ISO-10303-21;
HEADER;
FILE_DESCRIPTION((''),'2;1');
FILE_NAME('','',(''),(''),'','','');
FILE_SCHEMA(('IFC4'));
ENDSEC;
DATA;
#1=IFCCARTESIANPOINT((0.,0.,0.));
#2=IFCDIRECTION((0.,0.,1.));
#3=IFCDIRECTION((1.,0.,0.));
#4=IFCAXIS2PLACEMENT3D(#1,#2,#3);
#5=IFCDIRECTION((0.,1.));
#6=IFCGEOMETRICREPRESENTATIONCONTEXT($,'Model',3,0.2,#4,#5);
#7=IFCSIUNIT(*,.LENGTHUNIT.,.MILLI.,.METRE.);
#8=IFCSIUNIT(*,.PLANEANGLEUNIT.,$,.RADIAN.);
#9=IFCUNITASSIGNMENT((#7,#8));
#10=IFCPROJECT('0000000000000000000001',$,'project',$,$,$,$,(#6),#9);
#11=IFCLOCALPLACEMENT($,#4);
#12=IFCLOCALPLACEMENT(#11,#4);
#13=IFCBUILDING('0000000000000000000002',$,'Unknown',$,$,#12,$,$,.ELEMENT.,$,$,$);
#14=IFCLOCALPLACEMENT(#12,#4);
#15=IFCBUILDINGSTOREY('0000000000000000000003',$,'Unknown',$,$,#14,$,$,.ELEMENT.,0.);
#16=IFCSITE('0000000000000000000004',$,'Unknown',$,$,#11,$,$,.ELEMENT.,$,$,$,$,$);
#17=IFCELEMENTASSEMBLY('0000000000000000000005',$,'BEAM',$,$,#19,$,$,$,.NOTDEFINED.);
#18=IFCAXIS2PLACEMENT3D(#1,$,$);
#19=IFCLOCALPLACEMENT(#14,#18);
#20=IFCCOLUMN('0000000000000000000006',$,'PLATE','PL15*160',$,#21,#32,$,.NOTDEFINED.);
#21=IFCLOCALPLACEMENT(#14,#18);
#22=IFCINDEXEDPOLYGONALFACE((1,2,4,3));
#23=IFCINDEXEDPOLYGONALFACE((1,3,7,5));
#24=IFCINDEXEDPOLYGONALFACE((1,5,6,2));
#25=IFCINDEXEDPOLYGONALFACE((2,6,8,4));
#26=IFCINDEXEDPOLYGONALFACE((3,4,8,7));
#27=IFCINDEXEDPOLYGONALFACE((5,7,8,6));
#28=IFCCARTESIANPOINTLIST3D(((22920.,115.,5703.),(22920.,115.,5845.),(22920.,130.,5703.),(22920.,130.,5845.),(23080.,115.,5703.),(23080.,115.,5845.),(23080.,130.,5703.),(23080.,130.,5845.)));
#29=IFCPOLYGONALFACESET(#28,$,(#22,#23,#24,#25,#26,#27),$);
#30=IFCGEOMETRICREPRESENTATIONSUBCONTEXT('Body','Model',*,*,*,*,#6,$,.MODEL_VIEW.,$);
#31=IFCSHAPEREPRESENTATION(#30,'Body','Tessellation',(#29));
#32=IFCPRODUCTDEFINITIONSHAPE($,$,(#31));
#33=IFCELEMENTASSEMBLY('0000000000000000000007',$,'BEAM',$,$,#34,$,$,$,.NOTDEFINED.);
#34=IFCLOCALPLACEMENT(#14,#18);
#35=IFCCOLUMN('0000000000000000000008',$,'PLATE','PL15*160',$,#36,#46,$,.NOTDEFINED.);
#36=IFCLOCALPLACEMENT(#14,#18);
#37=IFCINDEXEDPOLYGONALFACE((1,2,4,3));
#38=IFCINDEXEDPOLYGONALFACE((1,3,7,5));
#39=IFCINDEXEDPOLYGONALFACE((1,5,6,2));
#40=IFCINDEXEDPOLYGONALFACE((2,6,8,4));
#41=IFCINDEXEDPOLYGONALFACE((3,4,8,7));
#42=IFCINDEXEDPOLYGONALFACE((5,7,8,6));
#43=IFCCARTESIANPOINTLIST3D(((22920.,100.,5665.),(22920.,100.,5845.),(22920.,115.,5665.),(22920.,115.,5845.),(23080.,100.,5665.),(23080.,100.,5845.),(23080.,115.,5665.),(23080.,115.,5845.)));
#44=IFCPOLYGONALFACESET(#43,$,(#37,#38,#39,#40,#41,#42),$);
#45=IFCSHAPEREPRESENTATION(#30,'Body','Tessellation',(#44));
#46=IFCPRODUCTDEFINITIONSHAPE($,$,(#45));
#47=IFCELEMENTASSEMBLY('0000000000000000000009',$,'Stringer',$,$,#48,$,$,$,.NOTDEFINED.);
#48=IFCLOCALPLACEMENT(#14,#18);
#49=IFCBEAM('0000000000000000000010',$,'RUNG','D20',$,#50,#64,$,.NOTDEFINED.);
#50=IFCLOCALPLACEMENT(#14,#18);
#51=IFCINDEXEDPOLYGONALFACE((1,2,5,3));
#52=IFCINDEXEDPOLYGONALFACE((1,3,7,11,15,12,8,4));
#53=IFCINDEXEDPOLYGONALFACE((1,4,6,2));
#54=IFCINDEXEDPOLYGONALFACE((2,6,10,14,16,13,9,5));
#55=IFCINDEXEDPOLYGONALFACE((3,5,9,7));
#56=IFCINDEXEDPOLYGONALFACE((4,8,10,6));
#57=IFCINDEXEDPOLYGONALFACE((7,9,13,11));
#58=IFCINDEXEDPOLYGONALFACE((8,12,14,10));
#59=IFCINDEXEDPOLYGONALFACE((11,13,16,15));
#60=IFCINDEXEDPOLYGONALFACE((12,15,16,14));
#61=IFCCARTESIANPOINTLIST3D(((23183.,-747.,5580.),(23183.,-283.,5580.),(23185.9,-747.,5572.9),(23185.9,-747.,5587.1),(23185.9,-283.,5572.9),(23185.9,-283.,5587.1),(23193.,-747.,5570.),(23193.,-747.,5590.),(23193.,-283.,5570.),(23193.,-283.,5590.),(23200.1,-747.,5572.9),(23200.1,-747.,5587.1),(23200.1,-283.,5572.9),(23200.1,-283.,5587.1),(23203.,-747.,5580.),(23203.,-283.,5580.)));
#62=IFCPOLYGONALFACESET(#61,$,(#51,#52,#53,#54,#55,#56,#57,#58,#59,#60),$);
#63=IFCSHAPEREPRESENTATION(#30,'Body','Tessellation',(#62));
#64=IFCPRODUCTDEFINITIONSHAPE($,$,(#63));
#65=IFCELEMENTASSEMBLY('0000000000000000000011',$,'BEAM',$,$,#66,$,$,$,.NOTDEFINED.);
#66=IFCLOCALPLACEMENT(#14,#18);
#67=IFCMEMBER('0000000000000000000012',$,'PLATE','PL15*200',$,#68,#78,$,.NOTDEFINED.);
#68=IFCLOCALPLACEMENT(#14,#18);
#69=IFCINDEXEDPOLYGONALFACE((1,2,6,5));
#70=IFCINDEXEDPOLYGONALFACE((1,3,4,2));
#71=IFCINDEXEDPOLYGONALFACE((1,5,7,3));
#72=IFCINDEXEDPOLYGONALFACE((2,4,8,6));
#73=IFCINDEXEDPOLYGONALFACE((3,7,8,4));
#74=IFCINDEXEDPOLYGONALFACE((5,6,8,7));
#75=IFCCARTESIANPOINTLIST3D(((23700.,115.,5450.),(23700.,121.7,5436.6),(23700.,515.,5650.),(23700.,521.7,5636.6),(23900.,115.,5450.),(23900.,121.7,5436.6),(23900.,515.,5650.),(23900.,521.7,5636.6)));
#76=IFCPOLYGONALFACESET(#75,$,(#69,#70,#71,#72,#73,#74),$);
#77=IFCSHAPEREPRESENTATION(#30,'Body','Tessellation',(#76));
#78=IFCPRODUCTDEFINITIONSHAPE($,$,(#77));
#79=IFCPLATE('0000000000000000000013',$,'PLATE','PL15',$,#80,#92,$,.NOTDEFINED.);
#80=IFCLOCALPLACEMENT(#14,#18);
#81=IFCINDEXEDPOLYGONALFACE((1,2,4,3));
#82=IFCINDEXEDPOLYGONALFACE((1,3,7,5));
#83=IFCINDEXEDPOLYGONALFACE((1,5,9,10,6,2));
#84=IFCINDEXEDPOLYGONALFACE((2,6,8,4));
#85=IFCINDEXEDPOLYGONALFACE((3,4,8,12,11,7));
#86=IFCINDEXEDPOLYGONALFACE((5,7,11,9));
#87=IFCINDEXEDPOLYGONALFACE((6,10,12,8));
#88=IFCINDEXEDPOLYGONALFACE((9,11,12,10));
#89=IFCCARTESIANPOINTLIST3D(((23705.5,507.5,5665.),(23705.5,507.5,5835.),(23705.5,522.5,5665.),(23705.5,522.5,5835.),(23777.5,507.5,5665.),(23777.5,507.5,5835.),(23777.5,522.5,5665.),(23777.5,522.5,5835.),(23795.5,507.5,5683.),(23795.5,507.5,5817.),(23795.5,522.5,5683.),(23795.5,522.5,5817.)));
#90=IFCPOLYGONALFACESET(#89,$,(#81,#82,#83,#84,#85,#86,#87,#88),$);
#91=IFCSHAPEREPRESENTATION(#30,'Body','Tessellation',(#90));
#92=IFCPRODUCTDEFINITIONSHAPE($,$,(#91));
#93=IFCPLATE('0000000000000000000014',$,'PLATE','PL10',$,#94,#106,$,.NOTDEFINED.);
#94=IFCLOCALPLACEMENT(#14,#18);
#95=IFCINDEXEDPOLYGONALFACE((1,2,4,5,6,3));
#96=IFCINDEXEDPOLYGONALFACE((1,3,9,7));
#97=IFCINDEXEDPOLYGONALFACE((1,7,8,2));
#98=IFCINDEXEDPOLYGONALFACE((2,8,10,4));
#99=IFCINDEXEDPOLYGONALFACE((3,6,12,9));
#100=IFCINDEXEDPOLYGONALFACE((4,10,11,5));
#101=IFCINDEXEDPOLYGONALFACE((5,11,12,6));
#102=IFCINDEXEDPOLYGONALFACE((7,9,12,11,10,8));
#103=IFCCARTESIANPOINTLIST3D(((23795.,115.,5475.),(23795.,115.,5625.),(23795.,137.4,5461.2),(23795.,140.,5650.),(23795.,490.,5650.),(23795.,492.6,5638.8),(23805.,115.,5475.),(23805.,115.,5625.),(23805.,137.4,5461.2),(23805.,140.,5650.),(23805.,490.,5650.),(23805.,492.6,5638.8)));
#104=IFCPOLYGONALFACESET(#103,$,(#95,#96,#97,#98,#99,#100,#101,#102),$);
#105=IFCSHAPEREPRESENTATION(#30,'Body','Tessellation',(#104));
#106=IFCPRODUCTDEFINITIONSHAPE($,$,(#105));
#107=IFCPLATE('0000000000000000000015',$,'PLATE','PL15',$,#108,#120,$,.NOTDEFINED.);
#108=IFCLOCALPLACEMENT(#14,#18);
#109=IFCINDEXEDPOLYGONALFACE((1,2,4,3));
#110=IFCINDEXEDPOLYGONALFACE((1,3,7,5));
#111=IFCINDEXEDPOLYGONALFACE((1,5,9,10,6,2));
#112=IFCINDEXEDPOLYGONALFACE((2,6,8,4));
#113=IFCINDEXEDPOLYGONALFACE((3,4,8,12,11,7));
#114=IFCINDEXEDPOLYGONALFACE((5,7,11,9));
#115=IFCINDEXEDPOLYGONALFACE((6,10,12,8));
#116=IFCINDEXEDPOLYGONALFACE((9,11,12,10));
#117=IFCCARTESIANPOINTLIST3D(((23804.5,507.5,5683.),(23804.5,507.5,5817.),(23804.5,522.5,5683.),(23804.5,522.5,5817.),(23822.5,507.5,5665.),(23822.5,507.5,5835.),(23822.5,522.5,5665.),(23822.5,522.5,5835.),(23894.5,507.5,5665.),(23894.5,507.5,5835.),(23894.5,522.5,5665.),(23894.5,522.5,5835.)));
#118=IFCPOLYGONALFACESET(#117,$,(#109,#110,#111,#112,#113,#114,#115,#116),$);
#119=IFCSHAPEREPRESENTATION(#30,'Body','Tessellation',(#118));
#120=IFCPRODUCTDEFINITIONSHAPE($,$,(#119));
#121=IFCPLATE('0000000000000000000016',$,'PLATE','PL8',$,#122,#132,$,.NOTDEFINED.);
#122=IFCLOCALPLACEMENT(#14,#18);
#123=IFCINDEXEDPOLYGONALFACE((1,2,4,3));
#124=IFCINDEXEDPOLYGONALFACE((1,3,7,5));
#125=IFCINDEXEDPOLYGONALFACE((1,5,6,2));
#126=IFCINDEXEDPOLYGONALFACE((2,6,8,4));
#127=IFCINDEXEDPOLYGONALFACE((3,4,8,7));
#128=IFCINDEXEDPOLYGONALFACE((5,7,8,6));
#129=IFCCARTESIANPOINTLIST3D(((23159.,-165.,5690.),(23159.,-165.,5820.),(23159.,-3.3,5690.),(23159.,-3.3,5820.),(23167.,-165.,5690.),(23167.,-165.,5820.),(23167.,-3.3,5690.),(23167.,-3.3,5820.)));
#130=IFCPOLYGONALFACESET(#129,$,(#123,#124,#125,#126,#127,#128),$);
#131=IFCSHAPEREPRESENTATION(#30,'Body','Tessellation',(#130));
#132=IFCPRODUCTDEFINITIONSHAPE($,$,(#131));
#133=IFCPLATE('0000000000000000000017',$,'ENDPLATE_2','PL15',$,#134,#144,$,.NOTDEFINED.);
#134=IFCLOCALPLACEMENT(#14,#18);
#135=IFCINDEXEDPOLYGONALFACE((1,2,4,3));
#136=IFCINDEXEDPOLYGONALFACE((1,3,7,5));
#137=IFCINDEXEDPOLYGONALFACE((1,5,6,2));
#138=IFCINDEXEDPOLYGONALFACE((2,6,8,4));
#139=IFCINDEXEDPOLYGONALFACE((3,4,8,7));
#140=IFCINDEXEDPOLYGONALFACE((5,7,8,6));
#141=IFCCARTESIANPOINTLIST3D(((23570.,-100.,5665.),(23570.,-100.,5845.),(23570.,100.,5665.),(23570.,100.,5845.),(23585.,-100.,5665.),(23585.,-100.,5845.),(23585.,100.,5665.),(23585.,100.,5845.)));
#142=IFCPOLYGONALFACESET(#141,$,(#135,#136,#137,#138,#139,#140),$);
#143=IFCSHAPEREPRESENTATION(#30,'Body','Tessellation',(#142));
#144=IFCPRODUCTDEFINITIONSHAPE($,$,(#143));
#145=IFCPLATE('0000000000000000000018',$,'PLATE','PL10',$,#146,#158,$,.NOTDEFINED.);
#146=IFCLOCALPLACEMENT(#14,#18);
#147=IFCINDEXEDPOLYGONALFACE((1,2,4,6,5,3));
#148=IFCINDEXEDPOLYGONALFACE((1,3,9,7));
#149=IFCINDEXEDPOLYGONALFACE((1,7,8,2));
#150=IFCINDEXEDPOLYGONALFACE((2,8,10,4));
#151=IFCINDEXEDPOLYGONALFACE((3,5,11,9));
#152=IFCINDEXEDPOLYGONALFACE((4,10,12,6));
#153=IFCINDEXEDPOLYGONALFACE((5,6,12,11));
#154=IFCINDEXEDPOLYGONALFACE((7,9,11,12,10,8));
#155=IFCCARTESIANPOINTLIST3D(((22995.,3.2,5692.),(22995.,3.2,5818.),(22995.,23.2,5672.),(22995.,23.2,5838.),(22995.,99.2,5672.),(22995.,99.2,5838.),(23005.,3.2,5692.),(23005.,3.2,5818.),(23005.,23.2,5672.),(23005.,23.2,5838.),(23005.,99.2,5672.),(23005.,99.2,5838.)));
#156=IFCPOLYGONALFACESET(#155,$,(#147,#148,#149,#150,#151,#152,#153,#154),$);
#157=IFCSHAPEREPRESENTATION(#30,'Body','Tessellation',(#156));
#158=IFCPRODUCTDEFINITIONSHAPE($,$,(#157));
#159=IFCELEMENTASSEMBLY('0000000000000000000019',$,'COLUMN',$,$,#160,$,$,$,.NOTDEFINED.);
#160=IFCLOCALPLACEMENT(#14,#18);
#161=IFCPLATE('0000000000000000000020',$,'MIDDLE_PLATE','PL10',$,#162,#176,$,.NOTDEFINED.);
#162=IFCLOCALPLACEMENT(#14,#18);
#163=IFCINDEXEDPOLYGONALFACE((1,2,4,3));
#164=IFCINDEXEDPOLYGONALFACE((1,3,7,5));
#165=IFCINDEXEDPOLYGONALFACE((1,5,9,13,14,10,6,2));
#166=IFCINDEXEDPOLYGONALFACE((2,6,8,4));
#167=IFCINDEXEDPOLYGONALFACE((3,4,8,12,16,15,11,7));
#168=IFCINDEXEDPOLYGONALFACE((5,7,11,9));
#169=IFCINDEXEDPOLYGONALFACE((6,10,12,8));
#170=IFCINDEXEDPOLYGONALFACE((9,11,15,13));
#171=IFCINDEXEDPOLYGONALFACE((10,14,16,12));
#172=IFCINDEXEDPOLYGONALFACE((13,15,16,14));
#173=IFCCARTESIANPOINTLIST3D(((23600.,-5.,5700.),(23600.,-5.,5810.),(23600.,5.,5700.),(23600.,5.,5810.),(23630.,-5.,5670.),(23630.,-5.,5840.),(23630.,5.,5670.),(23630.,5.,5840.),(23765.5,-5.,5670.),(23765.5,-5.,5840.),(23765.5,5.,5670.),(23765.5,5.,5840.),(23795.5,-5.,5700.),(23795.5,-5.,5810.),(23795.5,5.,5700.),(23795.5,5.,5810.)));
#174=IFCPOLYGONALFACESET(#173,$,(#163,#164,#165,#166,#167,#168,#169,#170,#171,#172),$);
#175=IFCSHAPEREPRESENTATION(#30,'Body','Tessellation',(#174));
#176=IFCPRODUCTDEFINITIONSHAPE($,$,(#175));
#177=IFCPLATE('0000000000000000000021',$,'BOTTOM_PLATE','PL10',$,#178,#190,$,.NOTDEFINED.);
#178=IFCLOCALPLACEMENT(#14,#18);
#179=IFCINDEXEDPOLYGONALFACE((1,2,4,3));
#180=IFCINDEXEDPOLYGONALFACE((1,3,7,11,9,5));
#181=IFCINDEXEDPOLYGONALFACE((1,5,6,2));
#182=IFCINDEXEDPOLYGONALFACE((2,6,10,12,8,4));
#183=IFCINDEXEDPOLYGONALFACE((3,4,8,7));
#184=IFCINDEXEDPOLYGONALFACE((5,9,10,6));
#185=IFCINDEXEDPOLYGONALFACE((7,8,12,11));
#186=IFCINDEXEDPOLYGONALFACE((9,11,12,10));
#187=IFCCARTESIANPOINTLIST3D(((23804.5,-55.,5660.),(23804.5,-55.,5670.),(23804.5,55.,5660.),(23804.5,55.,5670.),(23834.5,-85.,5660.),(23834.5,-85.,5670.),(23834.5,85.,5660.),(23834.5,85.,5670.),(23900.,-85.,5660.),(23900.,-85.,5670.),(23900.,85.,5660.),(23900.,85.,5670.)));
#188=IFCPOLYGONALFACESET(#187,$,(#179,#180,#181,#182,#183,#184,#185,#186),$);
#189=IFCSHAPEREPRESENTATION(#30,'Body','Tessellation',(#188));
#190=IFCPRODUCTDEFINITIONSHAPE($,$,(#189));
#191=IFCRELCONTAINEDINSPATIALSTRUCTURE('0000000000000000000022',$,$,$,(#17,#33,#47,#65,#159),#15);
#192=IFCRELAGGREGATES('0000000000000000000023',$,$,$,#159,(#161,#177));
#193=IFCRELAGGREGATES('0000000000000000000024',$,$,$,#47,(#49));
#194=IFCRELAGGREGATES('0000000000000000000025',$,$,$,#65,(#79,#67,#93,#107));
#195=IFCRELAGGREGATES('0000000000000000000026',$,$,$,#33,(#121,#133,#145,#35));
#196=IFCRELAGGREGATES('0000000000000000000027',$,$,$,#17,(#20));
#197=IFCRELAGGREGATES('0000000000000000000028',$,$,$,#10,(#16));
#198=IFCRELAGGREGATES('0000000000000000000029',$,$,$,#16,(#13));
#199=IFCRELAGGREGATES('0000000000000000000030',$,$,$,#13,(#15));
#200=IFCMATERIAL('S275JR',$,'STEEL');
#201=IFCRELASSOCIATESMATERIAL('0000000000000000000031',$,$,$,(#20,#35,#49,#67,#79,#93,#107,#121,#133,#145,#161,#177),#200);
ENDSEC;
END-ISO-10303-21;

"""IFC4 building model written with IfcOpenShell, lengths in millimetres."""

from ifc_helpers import new_model, si_unit, direction, frame, origin_with_axes, place, context, subcontext, project, spatial, line, indexed_curve, outline, extrude, material, element, aggregate, save


model = new_model("IFC4")

# Units and contexts
model_context = context("Model", 3, precision=0.2, world=origin_with_axes(), true_north=direction((0.0, 1.0)))
body_context = subcontext(model_context, "Body", "Model", "MODEL_VIEW")
ifc_project = project(units=[si_unit("LENGTHUNIT", "METRE", prefix="MILLI"), si_unit("PLANEANGLEUNIT", "RADIAN")], contexts=[model_context])

# Site, building, storey
site_placement = place(None, origin_with_axes())
site = spatial("IfcSite", under=ifc_project, at=site_placement, Name="Unknown", CompositionType="ELEMENT")
building_placement = place(site_placement, origin_with_axes())
building = spatial("IfcBuilding", under=site, at=building_placement, Name="Unknown", CompositionType="ELEMENT")
storey_placement = place(building_placement, origin_with_axes())
storey = spatial("IfcBuildingStorey", under=building, at=storey_placement, Name="Unknown", CompositionType="ELEMENT", Elevation=0.0)

# Element assemblies, columns
assembly_1_placement = place(storey_placement, frame((23000.0, 3600.0, 5774.0), z_axis=(-1.0, 0.0, 0.0), x_axis=(-0.000002, -1.0, 0.0)))
assembly_1 = element("IfcElementAssembly", 1, at=assembly_1_placement, inside=storey, Name="BEAM", PredefinedType="NOTDEFINED")
ifc_material_1 = material(Name="S275JR", Category="STEEL")
column_1_placement = place(assembly_1_placement, frame((3477.5, -71.0, 0.0), z_axis=(-1.0, 0.0, 0.0), x_axis=(0.0, 1.0, 0.0)))
column_1 = element("IfcColumn", 2, at=column_1_placement, material=ifc_material_1, Name="PLATE", Description="PL15*160", PredefinedType="NOTDEFINED", context=body_context, shape_type="SolidModel", body=[
    extrude(outline(indexed_curve([(-7.5, -80.0), (7.5, -80.0), (7.5, 80.0), (-7.5, 80.0)], segments=[line(1, 2, 3, 4, 1)])), frame((0.0, 0.0, 0.0), z_axis=(-1.0, 0.0, 0.0), x_axis=(0.0, 0.0, 1.0)), (0.0, -0.000002, -1.0), 142.0),
])
assembly_2_placement = place(storey_placement, frame((23800.0, 0.0, 5755.0), z_axis=(0.0, 1.0, 0.0), x_axis=(-1.0, 0.0, 0.0)))
assembly_2 = element("IfcElementAssembly", 3, at=assembly_2_placement, inside=storey, Name="BEAM", PredefinedType="NOTDEFINED")
column_2_placement = place(assembly_2_placement, frame((800.0, -90.0, 107.5), z_axis=(0.0, 0.0, 1.0), x_axis=(0.0, 1.0, 0.0)))
column_2 = element("IfcColumn", 4, at=column_2_placement, material=ifc_material_1, Name="PLATE", Description="PL15*160", PredefinedType="NOTDEFINED", context=body_context, shape_type="SolidModel", body=[
    extrude(outline(indexed_curve([(-7.5, -80.0), (7.5, -80.0), (7.5, 80.0), (-7.5, 80.0)], segments=[line(1, 2, 3, 4, 1)])), frame((0.0, 0.0, 0.0), z_axis=(-1.0, 0.0, 0.0), x_axis=(0.0, 0.0, 1.0)), (0.0, -0.000002, -1.0), 180.0),
])

# Element assembly, beam
assembly_3_placement = place(storey_placement, frame((23193.0, -780.0, 7430.0), z_axis=(0.0, -1.0, 0.000002), x_axis=(0.0, -0.000002, -1.0)))
assembly_3 = element("IfcElementAssembly", 5, at=assembly_3_placement, inside=storey, Name="Stringer", PredefinedType="NOTDEFINED")
beam_placement = place(assembly_3_placement, frame((1850.0, 0.0, -497.0), z_axis=(-1.0, 0.0, 0.0), x_axis=(0.0, 0.0, 1.0)))
beam = element("IfcBeam", 6, at=beam_placement, material=ifc_material_1, Name="RUNG", Description="D20", PredefinedType="NOTDEFINED", context=body_context, shape_type="SolidModel", body=[
    extrude(outline(indexed_curve([(10.0, 0.0), (7.1, 7.1), (0.0, 10.0), (-7.1, 7.1), (-10.0, 0.0), (-7.1, -7.1), (0.0, -10.0), (7.1, -7.1)], segments=[line(1, 2, 3, 4, 5, 6, 7, 8, 1)])), frame((0.0, 0.0, 0.0), z_axis=(-1.0, 0.0, 0.0), x_axis=(0.0, 0.0, 1.0)), (0.0, -0.000002, -1.0), 464.0),
])

# Element assembly, member, plates
assembly_4_placement = place(storey_placement, frame((23800.0, 3600.0, 5750.0), z_axis=(-1.0, 0.0, 0.0), x_axis=(-0.000002, -1.0, 0.0)))
assembly_4 = element("IfcElementAssembly", 7, at=assembly_4_placement, inside=storey, Name="BEAM", PredefinedType="NOTDEFINED")
member_placement = place(assembly_4_placement, frame((3481.6, -306.7, 0.0), z_axis=(-0.447214, -0.894427, 0.0), x_axis=(-0.894427, 0.447214, 0.0)))
member = element("IfcMember", 8, at=member_placement, material=ifc_material_1, Name="PLATE", Description="PL15*200", PredefinedType="NOTDEFINED", context=body_context, shape_type="SolidModel", body=[
    extrude(outline(indexed_curve([(-7.5, -100.0), (7.5, -100.0), (7.5, 100.0), (-7.5, 100.0)], segments=[line(1, 2, 3, 4, 1)])), frame((0.0, 0.0, 0.0), z_axis=(-1.0, 0.0, 0.0), x_axis=(0.0, 0.0, 1.0)), (0.0, -0.000002, -1.0), 447.2),
])
plate_1_placement = place(assembly_4_placement, frame((3085.0, -85.0, 4.5), z_axis=(-1.0, 0.0, 0.0), x_axis=(0.0, 0.0, 1.0)))
plate_1 = element("IfcPlate", 9, at=plate_1_placement, material=ifc_material_1, Name="PLATE", Description="PL15", PredefinedType="NOTDEFINED", context=body_context, shape_type="SolidModel", body=[
    extrude(outline(indexed_curve([(0.0, 18.0), (18.0, 0.0), (90.0, 0.0), (90.0, 170.0), (18.0, 170.0), (0.0, 152.0)], segments=[line(1, 2, 3, 4, 5, 6, 1)])), frame((0.0, 0.0, 7.5), z_axis=(0.0, 0.0, 1.0), x_axis=(1.0, 0.0, 0.0)), (0.0, -0.000002, -1.0), 15.0),
])
plate_2_placement = place(assembly_4_placement, frame((3485.0, -300.0, 0.0), z_axis=(0.0, 0.0, 1.0), x_axis=(0.0, 1.0, 0.0)))
plate_2 = element("IfcPlate", 10, at=plate_2_placement, material=ifc_material_1, Name="PLATE", Description="PL10", PredefinedType="NOTDEFINED", context=body_context, shape_type="SolidModel", body=[
    extrude(outline(indexed_curve([(11.2, 22.4), (25.0, 0.0), (175.0, 0.0), (200.0, 25.0), (200.0, 375.0), (188.8, 377.6)], segments=[line(1, 2, 3, 4, 5, 6, 1)])), frame((0.0, 0.0, 5.0), z_axis=(0.0, 0.0, 1.0), x_axis=(1.0, 0.0, 0.0)), (0.0, -0.000002, -1.0), 10.0),
])
plate_3_placement = place(assembly_4_placement, frame((3085.0, -85.0, -4.5), z_axis=(1.0, 0.0, 0.0), x_axis=(0.0, -0.000002, -1.0)))
plate_3 = element("IfcPlate", 11, at=plate_3_placement, material=ifc_material_1, Name="PLATE", Description="PL15", PredefinedType="NOTDEFINED", context=body_context, shape_type="SolidModel", body=[
    extrude(outline(indexed_curve([(0.0, 18.0), (18.0, 0.0), (90.0, 0.0), (90.0, 170.0), (18.0, 170.0), (0.0, 152.0)], segments=[line(1, 2, 3, 4, 5, 6, 1)])), frame((0.0, 0.0, 7.5), z_axis=(0.0, 0.0, 1.0), x_axis=(1.0, 0.0, 0.0)), (0.0, -0.000002, -1.0), 15.0),
])

# Plates
plate_4_placement = place(assembly_2_placement, frame((637.0, 65.0, -3.3), z_axis=(-1.0, 0.0, 0.0), x_axis=(0.0, -0.000002, -1.0)))
plate_4 = element("IfcPlate", 12, at=plate_4_placement, material=ifc_material_1, Name="PLATE", Description="PL8", PredefinedType="NOTDEFINED", context=body_context, shape_type="SolidModel", body=[
    extrude(outline(indexed_curve([(0.0, 0.0), (161.8, 0.0), (161.8, 130.0), (0.0, 130.0)], segments=[line(1, 2, 3, 4, 1)])), frame((0.0, 0.0, 4.0), z_axis=(0.0, 0.0, 1.0), x_axis=(1.0, 0.0, 0.0)), (0.0, -0.000002, -1.0), 8.0),
])
plate_5_placement = place(assembly_2_placement, frame((222.5, -90.0, -100.0), z_axis=(1.0, 0.0, 0.0), x_axis=(0.0, 1.0, 0.0)))
plate_5 = element("IfcPlate", 13, at=plate_5_placement, material=ifc_material_1, Name="ENDPLATE_2", Description="PL15", PredefinedType="NOTDEFINED", context=body_context, shape_type="SolidModel", body=[
    extrude(outline(indexed_curve([(0.0, 0.0), (180.0, 0.0), (180.0, 200.0), (0.0, 200.0)], segments=[line(1, 2, 3, 4, 1)])), frame((0.0, 0.0, 7.5), z_axis=(0.0, 0.0, 1.0), x_axis=(1.0, 0.0, 0.0)), (0.0, -0.000002, -1.0), 15.0),
])
plate_6_placement = place(assembly_2_placement, frame((800.0, -83.0, 3.2), z_axis=(-1.0, 0.0, 0.0), x_axis=(0.0, 0.0, 1.0)))
plate_6 = element("IfcPlate", 14, at=plate_6_placement, material=ifc_material_1, Name="PLATE", Description="PL10", PredefinedType="NOTDEFINED", context=body_context, shape_type="SolidModel", body=[
    extrude(outline(indexed_curve([(0.0, 20.0), (20.0, 0.0), (96.0, 0.0), (96.0, 166.0), (20.0, 166.0), (0.0, 146.0)], segments=[line(1, 2, 3, 4, 5, 6, 1)])), frame((0.0, 0.0, 5.0), z_axis=(0.0, 0.0, 1.0), x_axis=(1.0, 0.0, 0.0)), (0.0, -0.000002, -1.0), 10.0),
])

# Element assembly, plates
assembly_5_placement = place(storey_placement, frame((23800.0, 0.0, 200.0), z_axis=(-1.0, 0.0, 0.0), x_axis=(0.0, 0.0, 1.0)))
assembly_5 = element("IfcElementAssembly", 15, at=assembly_5_placement, inside=storey, Name="COLUMN", PredefinedType="NOTDEFINED")
plate_7_placement = place(assembly_5_placement, frame((5640.0, 0.0, 200.0), z_axis=(0.0, 1.0, 0.0), x_axis=(0.0, -0.000002, -1.0)))
plate_7 = element("IfcPlate", 16, at=plate_7_placement, material=ifc_material_1, Name="MIDDLE_PLATE", Description="PL10", PredefinedType="NOTDEFINED", context=body_context, shape_type="SolidModel", body=[
    extrude(outline(indexed_curve([(0.0, 30.0), (30.0, 0.0), (165.5, 0.0), (195.5, 30.0), (195.5, 140.0), (165.5, 170.0), (30.0, 170.0), (0.0, 140.0)], segments=[line(1, 2, 3, 4, 5, 6, 7, 8, 1)])), frame((0.0, 0.0, 5.0), z_axis=(0.0, 0.0, 1.0), x_axis=(1.0, 0.0, 0.0)), (0.0, -0.000002, -1.0), 10.0),
])
plate_8_placement = place(assembly_5_placement, frame((5465.0, -85.0, -4.5), z_axis=(1.0, 0.0, 0.0), x_axis=(0.0, -0.000002, -1.0)))
plate_8 = element("IfcPlate", 17, at=plate_8_placement, material=ifc_material_1, Name="BOTTOM_PLATE", Description="PL10", PredefinedType="NOTDEFINED", context=body_context, shape_type="SolidModel", body=[
    extrude(outline(indexed_curve([(0.0, 30.0), (30.0, 0.0), (95.5, 0.0), (95.5, 170.0), (30.0, 170.0), (0.0, 140.0)], segments=[line(1, 2, 3, 4, 5, 6, 1)])), frame((0.0, 0.0, 5.0), z_axis=(0.0, 0.0, 1.0), x_axis=(1.0, 0.0, 0.0)), (0.0, -0.000002, -1.0), 10.0),
])
aggregate(assembly_5, [plate_7, plate_8])

aggregate(assembly_3, [beam])
aggregate(assembly_4, [plate_1, member, plate_2, plate_3])
aggregate(assembly_2, [plate_4, plate_5, plate_6, column_2])
aggregate(assembly_1, [column_1])

save(model, "model.ifc")
